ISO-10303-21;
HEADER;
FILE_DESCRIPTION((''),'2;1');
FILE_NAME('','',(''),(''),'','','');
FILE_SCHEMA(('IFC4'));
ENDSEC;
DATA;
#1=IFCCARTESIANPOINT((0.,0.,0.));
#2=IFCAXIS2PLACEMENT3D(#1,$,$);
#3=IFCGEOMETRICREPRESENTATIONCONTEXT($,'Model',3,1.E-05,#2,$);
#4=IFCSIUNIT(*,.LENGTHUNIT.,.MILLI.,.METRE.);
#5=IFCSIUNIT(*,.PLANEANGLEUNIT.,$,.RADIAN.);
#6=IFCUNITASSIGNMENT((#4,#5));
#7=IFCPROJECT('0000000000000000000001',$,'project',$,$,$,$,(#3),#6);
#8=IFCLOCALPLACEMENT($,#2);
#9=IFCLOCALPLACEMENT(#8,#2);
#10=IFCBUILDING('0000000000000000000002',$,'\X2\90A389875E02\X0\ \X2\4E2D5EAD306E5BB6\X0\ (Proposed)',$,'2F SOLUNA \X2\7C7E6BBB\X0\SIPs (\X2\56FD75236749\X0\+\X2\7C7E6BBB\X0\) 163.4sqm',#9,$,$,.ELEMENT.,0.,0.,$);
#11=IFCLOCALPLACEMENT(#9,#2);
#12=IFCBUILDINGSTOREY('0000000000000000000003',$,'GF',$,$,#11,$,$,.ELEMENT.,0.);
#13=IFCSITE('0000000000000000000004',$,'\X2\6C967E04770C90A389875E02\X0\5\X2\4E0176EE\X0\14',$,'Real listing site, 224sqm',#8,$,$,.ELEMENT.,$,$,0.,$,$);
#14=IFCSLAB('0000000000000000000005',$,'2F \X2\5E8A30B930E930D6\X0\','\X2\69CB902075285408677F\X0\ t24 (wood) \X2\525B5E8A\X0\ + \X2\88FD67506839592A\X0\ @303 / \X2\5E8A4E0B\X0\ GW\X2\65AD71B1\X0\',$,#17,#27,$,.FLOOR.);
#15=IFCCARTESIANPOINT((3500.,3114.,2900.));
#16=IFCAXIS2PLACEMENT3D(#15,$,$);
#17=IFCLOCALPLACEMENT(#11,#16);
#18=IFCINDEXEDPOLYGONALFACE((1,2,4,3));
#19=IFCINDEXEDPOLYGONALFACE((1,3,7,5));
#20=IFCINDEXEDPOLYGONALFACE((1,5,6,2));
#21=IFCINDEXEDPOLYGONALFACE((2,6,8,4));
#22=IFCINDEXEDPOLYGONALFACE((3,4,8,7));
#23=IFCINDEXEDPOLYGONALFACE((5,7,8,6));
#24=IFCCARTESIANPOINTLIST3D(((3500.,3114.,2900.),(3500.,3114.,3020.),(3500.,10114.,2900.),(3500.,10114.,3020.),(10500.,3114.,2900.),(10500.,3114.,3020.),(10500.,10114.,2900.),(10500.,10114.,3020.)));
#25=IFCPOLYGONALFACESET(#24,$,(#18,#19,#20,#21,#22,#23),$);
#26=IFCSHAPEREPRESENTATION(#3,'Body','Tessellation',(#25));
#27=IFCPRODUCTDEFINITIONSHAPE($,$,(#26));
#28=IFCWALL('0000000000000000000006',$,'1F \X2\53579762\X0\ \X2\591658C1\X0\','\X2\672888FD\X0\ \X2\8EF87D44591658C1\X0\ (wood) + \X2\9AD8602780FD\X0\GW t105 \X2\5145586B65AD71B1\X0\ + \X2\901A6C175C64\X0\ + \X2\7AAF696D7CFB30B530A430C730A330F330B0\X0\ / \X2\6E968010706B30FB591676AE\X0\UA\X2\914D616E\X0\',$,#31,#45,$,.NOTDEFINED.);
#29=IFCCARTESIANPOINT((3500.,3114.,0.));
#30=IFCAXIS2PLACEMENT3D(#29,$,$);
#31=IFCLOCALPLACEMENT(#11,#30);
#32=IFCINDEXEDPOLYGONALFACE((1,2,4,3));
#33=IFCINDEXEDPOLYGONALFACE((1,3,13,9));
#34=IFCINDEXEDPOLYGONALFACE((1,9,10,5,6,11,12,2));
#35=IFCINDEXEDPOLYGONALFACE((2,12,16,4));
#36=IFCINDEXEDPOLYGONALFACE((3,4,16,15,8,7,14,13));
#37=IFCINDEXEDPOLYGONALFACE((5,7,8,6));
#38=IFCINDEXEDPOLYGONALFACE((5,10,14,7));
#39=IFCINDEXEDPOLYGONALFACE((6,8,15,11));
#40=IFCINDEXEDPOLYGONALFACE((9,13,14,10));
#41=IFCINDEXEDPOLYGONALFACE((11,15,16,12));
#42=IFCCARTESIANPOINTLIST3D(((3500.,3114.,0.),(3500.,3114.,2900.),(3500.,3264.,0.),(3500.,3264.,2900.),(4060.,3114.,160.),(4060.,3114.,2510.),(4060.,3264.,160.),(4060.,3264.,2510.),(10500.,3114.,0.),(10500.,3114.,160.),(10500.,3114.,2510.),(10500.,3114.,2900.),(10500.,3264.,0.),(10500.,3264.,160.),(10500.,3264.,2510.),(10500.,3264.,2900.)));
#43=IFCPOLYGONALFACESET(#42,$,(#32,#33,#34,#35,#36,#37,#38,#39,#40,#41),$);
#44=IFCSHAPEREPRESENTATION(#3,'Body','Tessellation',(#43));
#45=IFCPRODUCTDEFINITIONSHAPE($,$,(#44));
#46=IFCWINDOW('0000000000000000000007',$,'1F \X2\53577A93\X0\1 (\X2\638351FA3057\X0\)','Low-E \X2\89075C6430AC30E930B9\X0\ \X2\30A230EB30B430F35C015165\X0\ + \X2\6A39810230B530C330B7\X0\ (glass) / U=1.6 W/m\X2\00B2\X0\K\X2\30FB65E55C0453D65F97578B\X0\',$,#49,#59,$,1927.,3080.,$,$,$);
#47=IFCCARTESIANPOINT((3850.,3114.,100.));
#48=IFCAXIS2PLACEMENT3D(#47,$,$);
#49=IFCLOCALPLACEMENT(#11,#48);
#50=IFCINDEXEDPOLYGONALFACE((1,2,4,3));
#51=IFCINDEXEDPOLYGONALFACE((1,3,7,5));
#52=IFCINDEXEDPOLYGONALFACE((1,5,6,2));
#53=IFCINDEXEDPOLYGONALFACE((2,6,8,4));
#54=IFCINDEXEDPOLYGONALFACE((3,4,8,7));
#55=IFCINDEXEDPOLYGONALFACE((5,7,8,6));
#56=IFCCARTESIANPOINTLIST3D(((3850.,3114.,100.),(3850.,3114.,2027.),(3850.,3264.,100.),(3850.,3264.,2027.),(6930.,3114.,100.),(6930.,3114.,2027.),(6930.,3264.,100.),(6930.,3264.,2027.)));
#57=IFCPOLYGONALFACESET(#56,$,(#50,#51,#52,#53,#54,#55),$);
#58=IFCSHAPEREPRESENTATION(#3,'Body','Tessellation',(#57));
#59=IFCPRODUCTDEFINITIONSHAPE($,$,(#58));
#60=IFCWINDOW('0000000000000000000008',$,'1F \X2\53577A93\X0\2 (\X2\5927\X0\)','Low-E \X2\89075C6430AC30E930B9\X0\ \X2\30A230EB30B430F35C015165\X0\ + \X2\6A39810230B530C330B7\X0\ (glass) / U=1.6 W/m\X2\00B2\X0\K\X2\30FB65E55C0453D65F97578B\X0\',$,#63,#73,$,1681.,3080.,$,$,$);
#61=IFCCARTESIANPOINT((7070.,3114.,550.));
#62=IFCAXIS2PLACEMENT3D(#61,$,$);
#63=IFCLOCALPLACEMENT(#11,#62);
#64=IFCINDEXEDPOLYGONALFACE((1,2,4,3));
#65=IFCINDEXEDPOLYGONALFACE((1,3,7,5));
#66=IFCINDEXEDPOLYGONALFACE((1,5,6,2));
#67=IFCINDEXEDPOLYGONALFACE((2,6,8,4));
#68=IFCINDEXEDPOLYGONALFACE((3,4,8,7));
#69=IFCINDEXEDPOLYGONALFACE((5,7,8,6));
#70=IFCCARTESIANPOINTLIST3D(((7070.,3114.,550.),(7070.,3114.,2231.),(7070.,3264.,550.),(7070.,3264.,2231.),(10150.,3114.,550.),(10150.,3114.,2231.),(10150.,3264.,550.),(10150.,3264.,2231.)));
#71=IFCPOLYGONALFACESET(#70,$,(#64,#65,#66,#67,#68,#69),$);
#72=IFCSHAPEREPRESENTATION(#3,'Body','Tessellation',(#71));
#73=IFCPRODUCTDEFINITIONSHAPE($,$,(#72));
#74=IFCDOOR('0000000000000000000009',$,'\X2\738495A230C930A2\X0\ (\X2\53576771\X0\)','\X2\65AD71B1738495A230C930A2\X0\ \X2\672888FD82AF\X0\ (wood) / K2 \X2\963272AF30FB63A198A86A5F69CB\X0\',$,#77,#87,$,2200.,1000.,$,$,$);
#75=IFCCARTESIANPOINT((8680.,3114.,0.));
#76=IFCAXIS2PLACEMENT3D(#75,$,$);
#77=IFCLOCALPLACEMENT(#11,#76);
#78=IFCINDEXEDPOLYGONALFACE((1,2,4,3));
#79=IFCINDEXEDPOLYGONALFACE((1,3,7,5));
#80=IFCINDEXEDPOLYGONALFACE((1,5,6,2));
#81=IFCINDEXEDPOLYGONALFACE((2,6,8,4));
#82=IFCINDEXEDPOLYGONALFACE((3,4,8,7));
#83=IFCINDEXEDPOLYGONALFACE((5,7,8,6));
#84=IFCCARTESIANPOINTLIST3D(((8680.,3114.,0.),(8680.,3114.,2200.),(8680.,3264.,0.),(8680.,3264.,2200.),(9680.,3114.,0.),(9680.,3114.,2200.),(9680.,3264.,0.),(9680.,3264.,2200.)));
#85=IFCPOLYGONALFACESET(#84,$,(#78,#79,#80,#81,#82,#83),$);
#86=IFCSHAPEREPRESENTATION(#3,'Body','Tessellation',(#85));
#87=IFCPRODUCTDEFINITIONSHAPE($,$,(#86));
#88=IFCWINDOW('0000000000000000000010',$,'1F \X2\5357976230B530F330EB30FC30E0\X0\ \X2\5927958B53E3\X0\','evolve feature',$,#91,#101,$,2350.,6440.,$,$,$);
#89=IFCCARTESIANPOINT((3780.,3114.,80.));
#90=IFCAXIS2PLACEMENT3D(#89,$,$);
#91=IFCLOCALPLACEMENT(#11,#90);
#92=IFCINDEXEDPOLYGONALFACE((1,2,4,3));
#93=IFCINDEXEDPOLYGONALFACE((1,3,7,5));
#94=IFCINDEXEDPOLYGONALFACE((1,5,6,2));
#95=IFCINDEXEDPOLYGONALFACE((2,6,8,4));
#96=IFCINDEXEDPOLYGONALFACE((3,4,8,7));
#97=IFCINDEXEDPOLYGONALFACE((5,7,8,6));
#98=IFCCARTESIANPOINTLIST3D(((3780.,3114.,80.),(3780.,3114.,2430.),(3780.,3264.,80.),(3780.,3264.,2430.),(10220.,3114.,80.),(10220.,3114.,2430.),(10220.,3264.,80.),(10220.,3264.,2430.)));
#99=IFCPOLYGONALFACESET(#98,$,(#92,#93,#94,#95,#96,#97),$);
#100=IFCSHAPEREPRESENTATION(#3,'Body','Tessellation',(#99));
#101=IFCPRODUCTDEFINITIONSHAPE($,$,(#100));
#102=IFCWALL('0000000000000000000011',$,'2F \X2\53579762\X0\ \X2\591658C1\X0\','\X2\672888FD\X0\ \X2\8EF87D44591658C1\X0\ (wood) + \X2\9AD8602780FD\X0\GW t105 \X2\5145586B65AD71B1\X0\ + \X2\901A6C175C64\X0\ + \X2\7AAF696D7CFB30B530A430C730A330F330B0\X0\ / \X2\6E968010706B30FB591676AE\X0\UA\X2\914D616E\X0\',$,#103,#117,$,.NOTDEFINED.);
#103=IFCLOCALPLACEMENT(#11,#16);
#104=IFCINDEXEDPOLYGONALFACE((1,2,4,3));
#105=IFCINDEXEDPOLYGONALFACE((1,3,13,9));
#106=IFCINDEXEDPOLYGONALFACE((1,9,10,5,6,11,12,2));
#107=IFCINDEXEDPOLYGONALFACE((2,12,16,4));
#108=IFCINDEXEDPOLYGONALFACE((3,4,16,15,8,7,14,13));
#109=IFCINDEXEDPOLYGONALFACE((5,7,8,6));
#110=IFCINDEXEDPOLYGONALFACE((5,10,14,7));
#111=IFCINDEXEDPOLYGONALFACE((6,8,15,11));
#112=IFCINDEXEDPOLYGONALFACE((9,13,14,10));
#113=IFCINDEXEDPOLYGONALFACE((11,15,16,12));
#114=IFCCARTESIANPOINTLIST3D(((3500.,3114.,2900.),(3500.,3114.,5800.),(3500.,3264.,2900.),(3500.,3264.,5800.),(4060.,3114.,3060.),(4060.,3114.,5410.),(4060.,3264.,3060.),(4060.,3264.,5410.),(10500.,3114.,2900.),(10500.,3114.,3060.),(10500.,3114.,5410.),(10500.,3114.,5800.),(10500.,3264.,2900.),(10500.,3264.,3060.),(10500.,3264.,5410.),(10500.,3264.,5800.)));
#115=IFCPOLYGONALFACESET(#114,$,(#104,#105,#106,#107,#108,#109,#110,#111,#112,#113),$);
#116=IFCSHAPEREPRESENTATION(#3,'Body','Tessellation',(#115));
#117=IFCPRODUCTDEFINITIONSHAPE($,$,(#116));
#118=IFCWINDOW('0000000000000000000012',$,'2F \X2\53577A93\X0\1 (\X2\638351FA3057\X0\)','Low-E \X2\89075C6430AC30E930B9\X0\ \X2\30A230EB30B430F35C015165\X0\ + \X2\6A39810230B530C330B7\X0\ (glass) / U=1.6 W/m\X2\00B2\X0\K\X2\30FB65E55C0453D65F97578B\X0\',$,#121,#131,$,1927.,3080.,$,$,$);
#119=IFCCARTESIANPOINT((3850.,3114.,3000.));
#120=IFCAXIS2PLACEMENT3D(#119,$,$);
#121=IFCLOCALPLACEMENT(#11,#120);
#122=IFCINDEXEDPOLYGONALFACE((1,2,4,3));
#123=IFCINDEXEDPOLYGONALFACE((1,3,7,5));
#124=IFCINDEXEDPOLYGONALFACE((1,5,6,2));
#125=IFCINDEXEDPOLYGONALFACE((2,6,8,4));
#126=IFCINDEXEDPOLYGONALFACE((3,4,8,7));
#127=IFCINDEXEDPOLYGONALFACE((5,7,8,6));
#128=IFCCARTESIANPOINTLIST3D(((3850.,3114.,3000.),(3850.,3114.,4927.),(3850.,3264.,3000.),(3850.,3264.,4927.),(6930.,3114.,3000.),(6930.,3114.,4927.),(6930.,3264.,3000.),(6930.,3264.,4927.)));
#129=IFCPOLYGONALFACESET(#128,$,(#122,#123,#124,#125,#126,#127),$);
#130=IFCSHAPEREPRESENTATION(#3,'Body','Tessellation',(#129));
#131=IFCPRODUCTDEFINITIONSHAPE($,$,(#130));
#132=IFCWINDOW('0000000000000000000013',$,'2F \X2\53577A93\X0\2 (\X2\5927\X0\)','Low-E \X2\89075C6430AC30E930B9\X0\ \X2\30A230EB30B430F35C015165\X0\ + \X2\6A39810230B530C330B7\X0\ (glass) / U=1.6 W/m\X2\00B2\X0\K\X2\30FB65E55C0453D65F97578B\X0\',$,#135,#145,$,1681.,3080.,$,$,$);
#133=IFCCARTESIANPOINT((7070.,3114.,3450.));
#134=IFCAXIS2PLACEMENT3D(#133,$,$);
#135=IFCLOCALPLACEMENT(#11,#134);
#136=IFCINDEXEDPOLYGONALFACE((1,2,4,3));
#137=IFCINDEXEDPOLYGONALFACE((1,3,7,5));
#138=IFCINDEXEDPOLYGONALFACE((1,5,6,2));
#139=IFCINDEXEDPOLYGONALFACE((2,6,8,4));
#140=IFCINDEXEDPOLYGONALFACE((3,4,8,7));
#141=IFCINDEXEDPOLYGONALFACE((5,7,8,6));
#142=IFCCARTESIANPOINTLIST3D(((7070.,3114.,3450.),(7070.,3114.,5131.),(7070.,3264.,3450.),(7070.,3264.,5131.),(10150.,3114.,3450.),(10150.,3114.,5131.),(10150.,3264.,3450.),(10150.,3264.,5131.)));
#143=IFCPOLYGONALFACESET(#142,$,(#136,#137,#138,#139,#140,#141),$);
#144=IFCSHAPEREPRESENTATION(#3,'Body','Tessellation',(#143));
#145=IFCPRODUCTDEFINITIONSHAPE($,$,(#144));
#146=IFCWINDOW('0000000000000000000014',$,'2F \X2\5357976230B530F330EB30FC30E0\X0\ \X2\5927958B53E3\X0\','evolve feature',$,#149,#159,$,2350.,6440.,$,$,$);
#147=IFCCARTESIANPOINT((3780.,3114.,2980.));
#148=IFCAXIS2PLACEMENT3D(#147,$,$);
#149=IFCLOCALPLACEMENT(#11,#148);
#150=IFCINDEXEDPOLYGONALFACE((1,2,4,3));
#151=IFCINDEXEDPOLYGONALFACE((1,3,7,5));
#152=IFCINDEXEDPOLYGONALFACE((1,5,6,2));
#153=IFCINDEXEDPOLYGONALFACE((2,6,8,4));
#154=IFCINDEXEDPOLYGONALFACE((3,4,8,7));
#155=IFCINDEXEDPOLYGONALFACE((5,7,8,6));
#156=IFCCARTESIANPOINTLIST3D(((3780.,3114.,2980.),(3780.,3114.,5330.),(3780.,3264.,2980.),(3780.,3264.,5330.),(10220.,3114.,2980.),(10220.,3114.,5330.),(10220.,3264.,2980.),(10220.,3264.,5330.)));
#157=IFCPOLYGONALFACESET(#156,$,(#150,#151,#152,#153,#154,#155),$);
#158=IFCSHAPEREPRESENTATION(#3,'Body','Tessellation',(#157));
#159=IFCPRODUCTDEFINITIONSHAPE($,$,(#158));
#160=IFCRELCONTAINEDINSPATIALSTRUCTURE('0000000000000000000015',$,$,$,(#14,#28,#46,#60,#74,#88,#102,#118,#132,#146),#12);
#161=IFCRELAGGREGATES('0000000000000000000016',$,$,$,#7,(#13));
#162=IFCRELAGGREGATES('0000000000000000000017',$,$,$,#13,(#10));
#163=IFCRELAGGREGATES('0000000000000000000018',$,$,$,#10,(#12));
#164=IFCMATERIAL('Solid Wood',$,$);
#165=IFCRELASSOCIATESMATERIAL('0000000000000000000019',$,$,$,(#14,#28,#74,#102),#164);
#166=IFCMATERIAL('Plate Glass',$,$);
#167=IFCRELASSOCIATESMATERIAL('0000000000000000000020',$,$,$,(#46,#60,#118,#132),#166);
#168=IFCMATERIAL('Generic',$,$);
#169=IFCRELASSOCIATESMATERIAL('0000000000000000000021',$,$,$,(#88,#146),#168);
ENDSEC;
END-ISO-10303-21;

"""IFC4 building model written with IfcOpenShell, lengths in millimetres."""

from ifc_helpers import new_model, si_unit, frame, frame_2d, origin, place, context, project, spatial, rectangle, extrude, material, element, fill, save


model = new_model("IFC4")

# Units and contexts
model_context = context("Model", 3, precision=1e-05, world=origin())
ifc_project = project(units=[si_unit("LENGTHUNIT", "METRE", prefix="MILLI"), si_unit("PLANEANGLEUNIT", "RADIAN")], contexts=[model_context])

# Site, building, storey
site_placement = place(None, origin())
site = spatial("IfcSite", under=ifc_project, at=site_placement, Name="沖縄県那覇市5丁目14", ObjectType="Real listing site, 224sqm", CompositionType="ELEMENT", RefElevation=0.0)
building_placement = place(site_placement, origin())
building = spatial("IfcBuilding", under=site, at=building_placement, Name="那覇市 中庭の家 (Proposed)", ObjectType="2F SOLUNA 籾殻SIPs (国産杉+籾殻) 163.4sqm", CompositionType="ELEMENT", ElevationOfRefHeight=0.0, ElevationOfTerrain=0.0)
storey_placement = place(building_placement, origin())
storey = spatial("IfcBuildingStorey", under=building, at=storey_placement, Name="GF", CompositionType="ELEMENT", Elevation=0.0)

# Slab
ifc_material_1 = material(Name="Solid Wood")
slab_1_placement = place(storey_placement, frame((3500.0, 3114.0, 2900.0)))
element("IfcSlab", 1, at=slab_1_placement, inside=storey, material=ifc_material_1, Name="2F 床スラブ", Description="構造用合板 t24 (wood) 剛床 + 製材根太 @303 / 床下 GW断熱", PredefinedType="FLOOR", context=model_context, shape_type="SweptSolid", body=[
    extrude(rectangle(XDim=7000.0, YDim=7000.0, at=frame_2d((3500.0, 3500.0))), frame((3500.0, 3114.0, 2900.0)), (0.0, 0.0, 1.0), 120.0),
])
ifc_material_2 = material(Name="Generic")

# Wall, openings, windows, door
wall_1_placement = place(storey_placement, frame((3500.0, 3114.0, 0.0)))
wall_1 = element("IfcWall", 2, at=wall_1_placement, inside=storey, material=ifc_material_1, Name="1F 南面 外壁", Description="木製 軸組外壁 (wood) + 高性能GW t105 充填断熱 + 通気層 + 窯業系サイディング / 準耐火・外皮UA配慮", PredefinedType="NOTDEFINED", context=model_context, shape_type="SweptSolid", body=[
    extrude(rectangle(XDim=7000.0, YDim=150.0, at=frame_2d((3500.0, 75.0))), frame((3500.0, 3114.0, 0.0)), (0.0, 0.0, 1.0), 2900.0),
])
opening_1_placement = place(storey_placement, frame((3850.0, 3114.0, 100.0)))
opening_1 = element("IfcOpeningElement", 3, at=opening_1_placement, cuts=wall_1, PredefinedType="NOTDEFINED", context=model_context, shape_type="SweptSolid", body=[
    extrude(rectangle(XDim=3080.0, YDim=150.0, at=frame_2d((1540.0, 75.0))), frame((3850.0, 3114.0, 100.0)), (0.0, 0.0, 1.0), 1927.0),
])
opening_2_placement = place(storey_placement, frame((7070.0, 3114.0, 550.0)))
opening_2 = element("IfcOpeningElement", 4, at=opening_2_placement, cuts=wall_1, PredefinedType="NOTDEFINED", context=model_context, shape_type="SweptSolid", body=[
    extrude(rectangle(XDim=3080.0, YDim=150.0, at=frame_2d((1540.0, 75.0))), frame((7070.0, 3114.0, 550.0)), (0.0, 0.0, 1.0), 1681.0),
])
opening_3_placement = place(storey_placement, frame((8680.0, 3114.0, 0.0)))
opening_3 = element("IfcOpeningElement", 5, at=opening_3_placement, cuts=wall_1, PredefinedType="NOTDEFINED", context=model_context, shape_type="SweptSolid", body=[
    extrude(rectangle(XDim=1000.0, YDim=150.0, at=frame_2d((500.0, 75.0))), frame((8680.0, 3114.0, 0.0)), (0.0, 0.0, 1.0), 2200.0),
])
opening_4_placement = place(storey_placement, frame((3780.0, 3114.0, 80.0)))
opening_4 = element("IfcOpeningElement", 6, at=opening_4_placement, cuts=wall_1, PredefinedType="NOTDEFINED", context=model_context, shape_type="SweptSolid", body=[
    extrude(rectangle(XDim=6440.0, YDim=150.0, at=frame_2d((3220.0, 75.0))), frame((3780.0, 3114.0, 80.0)), (0.0, 0.0, 1.0), 2350.0),
])
ifc_material_3 = material(Name="Plate Glass")
window_1_placement = place(storey_placement, frame((3850.0, 3114.0, 100.0)))
window_1 = element("IfcWindow", 7, at=window_1_placement, inside=storey, material=ifc_material_3, Name="1F 南窓1 (掃出し)", Description="Low-E 複層ガラス アルゴン封入 + 樹脂サッシ (glass) / U=1.6 W/m²K・日射取得型", OverallHeight=1927.0, OverallWidth=3080.0, context=model_context, shape_type="SweptSolid", body=[
    extrude(rectangle(XDim=3080.0, YDim=150.0, at=frame_2d((1540.0, 75.0))), frame((3850.0, 3114.0, 100.0)), (0.0, 0.0, 1.0), 1927.0),
])
fill(opening_1, window_1)
window_2_placement = place(storey_placement, frame((7070.0, 3114.0, 550.0)))
window_2 = element("IfcWindow", 8, at=window_2_placement, inside=storey, material=ifc_material_3, Name="1F 南窓2 (大)", Description="Low-E 複層ガラス アルゴン封入 + 樹脂サッシ (glass) / U=1.6 W/m²K・日射取得型", OverallHeight=1681.0, OverallWidth=3080.0, context=model_context, shape_type="SweptSolid", body=[
    extrude(rectangle(XDim=3080.0, YDim=150.0, at=frame_2d((1540.0, 75.0))), frame((7070.0, 3114.0, 550.0)), (0.0, 0.0, 1.0), 1681.0),
])
fill(opening_2, window_2)
door_placement = place(storey_placement, frame((8680.0, 3114.0, 0.0)))
door = element("IfcDoor", 9, at=door_placement, inside=storey, material=ifc_material_1, Name="玄関ドア (南東)", Description="断熱玄関ドア 木製芯 (wood) / K2 防犯・採風機構", OverallHeight=2200.0, OverallWidth=1000.0, context=model_context, shape_type="SweptSolid", body=[
    extrude(rectangle(XDim=1000.0, YDim=150.0, at=frame_2d((500.0, 75.0))), frame((8680.0, 3114.0, 0.0)), (0.0, 0.0, 1.0), 2200.0),
])
fill(opening_3, door)
window_3_placement = place(storey_placement, frame((3780.0, 3114.0, 80.0)))
window_3 = element("IfcWindow", 10, at=window_3_placement, inside=storey, material=ifc_material_2, Name="1F 南面サンルーム 大開口", Description="evolve feature", OverallHeight=2350.0, OverallWidth=6440.0, context=model_context, shape_type="SweptSolid", body=[
    extrude(rectangle(XDim=6440.0, YDim=150.0, at=frame_2d((3220.0, 75.0))), frame((3780.0, 3114.0, 80.0)), (0.0, 0.0, 1.0), 2350.0),
])
fill(opening_4, window_3)

# Wall, openings, windows
wall_2_placement = place(storey_placement, frame((3500.0, 3114.0, 2900.0)))
wall_2 = element("IfcWall", 11, at=wall_2_placement, inside=storey, material=ifc_material_1, Name="2F 南面 外壁", Description="木製 軸組外壁 (wood) + 高性能GW t105 充填断熱 + 通気層 + 窯業系サイディング / 準耐火・外皮UA配慮", PredefinedType="NOTDEFINED", context=model_context, shape_type="SweptSolid", body=[
    extrude(rectangle(XDim=7000.0, YDim=150.0, at=frame_2d((3500.0, 75.0))), frame((3500.0, 3114.0, 2900.0)), (0.0, 0.0, 1.0), 2900.0),
])
opening_5_placement = place(storey_placement, frame((3850.0, 3114.0, 3000.0)))
opening_5 = element("IfcOpeningElement", 12, at=opening_5_placement, cuts=wall_2, PredefinedType="NOTDEFINED", context=model_context, shape_type="SweptSolid", body=[
    extrude(rectangle(XDim=3080.0, YDim=150.0, at=frame_2d((1540.0, 75.0))), frame((3850.0, 3114.0, 3000.0)), (0.0, 0.0, 1.0), 1927.0),
])
opening_6_placement = place(storey_placement, frame((7070.0, 3114.0, 3450.0)))
opening_6 = element("IfcOpeningElement", 13, at=opening_6_placement, cuts=wall_2, PredefinedType="NOTDEFINED", context=model_context, shape_type="SweptSolid", body=[
    extrude(rectangle(XDim=3080.0, YDim=150.0, at=frame_2d((1540.0, 75.0))), frame((7070.0, 3114.0, 3450.0)), (0.0, 0.0, 1.0), 1681.0),
])
opening_7_placement = place(storey_placement, frame((3780.0, 3114.0, 2980.0)))
opening_7 = element("IfcOpeningElement", 14, at=opening_7_placement, cuts=wall_2, PredefinedType="NOTDEFINED", context=model_context, shape_type="SweptSolid", body=[
    extrude(rectangle(XDim=6440.0, YDim=150.0, at=frame_2d((3220.0, 75.0))), frame((3780.0, 3114.0, 2980.0)), (0.0, 0.0, 1.0), 2350.0),
])
window_4_placement = place(storey_placement, frame((3850.0, 3114.0, 3000.0)))
window_4 = element("IfcWindow", 15, at=window_4_placement, inside=storey, material=ifc_material_3, Name="2F 南窓1 (掃出し)", Description="Low-E 複層ガラス アルゴン封入 + 樹脂サッシ (glass) / U=1.6 W/m²K・日射取得型", OverallHeight=1927.0, OverallWidth=3080.0, context=model_context, shape_type="SweptSolid", body=[
    extrude(rectangle(XDim=3080.0, YDim=150.0, at=frame_2d((1540.0, 75.0))), frame((3850.0, 3114.0, 3000.0)), (0.0, 0.0, 1.0), 1927.0),
])
fill(opening_5, window_4)
window_5_placement = place(storey_placement, frame((7070.0, 3114.0, 3450.0)))
window_5 = element("IfcWindow", 16, at=window_5_placement, inside=storey, material=ifc_material_3, Name="2F 南窓2 (大)", Description="Low-E 複層ガラス アルゴン封入 + 樹脂サッシ (glass) / U=1.6 W/m²K・日射取得型", OverallHeight=1681.0, OverallWidth=3080.0, context=model_context, shape_type="SweptSolid", body=[
    extrude(rectangle(XDim=3080.0, YDim=150.0, at=frame_2d((1540.0, 75.0))), frame((7070.0, 3114.0, 3450.0)), (0.0, 0.0, 1.0), 1681.0),
])
fill(opening_6, window_5)
window_6_placement = place(storey_placement, frame((3780.0, 3114.0, 2980.0)))
window_6 = element("IfcWindow", 17, at=window_6_placement, inside=storey, material=ifc_material_2, Name="2F 南面サンルーム 大開口", Description="evolve feature", OverallHeight=2350.0, OverallWidth=6440.0, context=model_context, shape_type="SweptSolid", body=[
    extrude(rectangle(XDim=6440.0, YDim=150.0, at=frame_2d((3220.0, 75.0))), frame((3780.0, 3114.0, 2980.0)), (0.0, 0.0, 1.0), 2350.0),
])
fill(opening_7, window_6)

save(model, "model.ifc")
